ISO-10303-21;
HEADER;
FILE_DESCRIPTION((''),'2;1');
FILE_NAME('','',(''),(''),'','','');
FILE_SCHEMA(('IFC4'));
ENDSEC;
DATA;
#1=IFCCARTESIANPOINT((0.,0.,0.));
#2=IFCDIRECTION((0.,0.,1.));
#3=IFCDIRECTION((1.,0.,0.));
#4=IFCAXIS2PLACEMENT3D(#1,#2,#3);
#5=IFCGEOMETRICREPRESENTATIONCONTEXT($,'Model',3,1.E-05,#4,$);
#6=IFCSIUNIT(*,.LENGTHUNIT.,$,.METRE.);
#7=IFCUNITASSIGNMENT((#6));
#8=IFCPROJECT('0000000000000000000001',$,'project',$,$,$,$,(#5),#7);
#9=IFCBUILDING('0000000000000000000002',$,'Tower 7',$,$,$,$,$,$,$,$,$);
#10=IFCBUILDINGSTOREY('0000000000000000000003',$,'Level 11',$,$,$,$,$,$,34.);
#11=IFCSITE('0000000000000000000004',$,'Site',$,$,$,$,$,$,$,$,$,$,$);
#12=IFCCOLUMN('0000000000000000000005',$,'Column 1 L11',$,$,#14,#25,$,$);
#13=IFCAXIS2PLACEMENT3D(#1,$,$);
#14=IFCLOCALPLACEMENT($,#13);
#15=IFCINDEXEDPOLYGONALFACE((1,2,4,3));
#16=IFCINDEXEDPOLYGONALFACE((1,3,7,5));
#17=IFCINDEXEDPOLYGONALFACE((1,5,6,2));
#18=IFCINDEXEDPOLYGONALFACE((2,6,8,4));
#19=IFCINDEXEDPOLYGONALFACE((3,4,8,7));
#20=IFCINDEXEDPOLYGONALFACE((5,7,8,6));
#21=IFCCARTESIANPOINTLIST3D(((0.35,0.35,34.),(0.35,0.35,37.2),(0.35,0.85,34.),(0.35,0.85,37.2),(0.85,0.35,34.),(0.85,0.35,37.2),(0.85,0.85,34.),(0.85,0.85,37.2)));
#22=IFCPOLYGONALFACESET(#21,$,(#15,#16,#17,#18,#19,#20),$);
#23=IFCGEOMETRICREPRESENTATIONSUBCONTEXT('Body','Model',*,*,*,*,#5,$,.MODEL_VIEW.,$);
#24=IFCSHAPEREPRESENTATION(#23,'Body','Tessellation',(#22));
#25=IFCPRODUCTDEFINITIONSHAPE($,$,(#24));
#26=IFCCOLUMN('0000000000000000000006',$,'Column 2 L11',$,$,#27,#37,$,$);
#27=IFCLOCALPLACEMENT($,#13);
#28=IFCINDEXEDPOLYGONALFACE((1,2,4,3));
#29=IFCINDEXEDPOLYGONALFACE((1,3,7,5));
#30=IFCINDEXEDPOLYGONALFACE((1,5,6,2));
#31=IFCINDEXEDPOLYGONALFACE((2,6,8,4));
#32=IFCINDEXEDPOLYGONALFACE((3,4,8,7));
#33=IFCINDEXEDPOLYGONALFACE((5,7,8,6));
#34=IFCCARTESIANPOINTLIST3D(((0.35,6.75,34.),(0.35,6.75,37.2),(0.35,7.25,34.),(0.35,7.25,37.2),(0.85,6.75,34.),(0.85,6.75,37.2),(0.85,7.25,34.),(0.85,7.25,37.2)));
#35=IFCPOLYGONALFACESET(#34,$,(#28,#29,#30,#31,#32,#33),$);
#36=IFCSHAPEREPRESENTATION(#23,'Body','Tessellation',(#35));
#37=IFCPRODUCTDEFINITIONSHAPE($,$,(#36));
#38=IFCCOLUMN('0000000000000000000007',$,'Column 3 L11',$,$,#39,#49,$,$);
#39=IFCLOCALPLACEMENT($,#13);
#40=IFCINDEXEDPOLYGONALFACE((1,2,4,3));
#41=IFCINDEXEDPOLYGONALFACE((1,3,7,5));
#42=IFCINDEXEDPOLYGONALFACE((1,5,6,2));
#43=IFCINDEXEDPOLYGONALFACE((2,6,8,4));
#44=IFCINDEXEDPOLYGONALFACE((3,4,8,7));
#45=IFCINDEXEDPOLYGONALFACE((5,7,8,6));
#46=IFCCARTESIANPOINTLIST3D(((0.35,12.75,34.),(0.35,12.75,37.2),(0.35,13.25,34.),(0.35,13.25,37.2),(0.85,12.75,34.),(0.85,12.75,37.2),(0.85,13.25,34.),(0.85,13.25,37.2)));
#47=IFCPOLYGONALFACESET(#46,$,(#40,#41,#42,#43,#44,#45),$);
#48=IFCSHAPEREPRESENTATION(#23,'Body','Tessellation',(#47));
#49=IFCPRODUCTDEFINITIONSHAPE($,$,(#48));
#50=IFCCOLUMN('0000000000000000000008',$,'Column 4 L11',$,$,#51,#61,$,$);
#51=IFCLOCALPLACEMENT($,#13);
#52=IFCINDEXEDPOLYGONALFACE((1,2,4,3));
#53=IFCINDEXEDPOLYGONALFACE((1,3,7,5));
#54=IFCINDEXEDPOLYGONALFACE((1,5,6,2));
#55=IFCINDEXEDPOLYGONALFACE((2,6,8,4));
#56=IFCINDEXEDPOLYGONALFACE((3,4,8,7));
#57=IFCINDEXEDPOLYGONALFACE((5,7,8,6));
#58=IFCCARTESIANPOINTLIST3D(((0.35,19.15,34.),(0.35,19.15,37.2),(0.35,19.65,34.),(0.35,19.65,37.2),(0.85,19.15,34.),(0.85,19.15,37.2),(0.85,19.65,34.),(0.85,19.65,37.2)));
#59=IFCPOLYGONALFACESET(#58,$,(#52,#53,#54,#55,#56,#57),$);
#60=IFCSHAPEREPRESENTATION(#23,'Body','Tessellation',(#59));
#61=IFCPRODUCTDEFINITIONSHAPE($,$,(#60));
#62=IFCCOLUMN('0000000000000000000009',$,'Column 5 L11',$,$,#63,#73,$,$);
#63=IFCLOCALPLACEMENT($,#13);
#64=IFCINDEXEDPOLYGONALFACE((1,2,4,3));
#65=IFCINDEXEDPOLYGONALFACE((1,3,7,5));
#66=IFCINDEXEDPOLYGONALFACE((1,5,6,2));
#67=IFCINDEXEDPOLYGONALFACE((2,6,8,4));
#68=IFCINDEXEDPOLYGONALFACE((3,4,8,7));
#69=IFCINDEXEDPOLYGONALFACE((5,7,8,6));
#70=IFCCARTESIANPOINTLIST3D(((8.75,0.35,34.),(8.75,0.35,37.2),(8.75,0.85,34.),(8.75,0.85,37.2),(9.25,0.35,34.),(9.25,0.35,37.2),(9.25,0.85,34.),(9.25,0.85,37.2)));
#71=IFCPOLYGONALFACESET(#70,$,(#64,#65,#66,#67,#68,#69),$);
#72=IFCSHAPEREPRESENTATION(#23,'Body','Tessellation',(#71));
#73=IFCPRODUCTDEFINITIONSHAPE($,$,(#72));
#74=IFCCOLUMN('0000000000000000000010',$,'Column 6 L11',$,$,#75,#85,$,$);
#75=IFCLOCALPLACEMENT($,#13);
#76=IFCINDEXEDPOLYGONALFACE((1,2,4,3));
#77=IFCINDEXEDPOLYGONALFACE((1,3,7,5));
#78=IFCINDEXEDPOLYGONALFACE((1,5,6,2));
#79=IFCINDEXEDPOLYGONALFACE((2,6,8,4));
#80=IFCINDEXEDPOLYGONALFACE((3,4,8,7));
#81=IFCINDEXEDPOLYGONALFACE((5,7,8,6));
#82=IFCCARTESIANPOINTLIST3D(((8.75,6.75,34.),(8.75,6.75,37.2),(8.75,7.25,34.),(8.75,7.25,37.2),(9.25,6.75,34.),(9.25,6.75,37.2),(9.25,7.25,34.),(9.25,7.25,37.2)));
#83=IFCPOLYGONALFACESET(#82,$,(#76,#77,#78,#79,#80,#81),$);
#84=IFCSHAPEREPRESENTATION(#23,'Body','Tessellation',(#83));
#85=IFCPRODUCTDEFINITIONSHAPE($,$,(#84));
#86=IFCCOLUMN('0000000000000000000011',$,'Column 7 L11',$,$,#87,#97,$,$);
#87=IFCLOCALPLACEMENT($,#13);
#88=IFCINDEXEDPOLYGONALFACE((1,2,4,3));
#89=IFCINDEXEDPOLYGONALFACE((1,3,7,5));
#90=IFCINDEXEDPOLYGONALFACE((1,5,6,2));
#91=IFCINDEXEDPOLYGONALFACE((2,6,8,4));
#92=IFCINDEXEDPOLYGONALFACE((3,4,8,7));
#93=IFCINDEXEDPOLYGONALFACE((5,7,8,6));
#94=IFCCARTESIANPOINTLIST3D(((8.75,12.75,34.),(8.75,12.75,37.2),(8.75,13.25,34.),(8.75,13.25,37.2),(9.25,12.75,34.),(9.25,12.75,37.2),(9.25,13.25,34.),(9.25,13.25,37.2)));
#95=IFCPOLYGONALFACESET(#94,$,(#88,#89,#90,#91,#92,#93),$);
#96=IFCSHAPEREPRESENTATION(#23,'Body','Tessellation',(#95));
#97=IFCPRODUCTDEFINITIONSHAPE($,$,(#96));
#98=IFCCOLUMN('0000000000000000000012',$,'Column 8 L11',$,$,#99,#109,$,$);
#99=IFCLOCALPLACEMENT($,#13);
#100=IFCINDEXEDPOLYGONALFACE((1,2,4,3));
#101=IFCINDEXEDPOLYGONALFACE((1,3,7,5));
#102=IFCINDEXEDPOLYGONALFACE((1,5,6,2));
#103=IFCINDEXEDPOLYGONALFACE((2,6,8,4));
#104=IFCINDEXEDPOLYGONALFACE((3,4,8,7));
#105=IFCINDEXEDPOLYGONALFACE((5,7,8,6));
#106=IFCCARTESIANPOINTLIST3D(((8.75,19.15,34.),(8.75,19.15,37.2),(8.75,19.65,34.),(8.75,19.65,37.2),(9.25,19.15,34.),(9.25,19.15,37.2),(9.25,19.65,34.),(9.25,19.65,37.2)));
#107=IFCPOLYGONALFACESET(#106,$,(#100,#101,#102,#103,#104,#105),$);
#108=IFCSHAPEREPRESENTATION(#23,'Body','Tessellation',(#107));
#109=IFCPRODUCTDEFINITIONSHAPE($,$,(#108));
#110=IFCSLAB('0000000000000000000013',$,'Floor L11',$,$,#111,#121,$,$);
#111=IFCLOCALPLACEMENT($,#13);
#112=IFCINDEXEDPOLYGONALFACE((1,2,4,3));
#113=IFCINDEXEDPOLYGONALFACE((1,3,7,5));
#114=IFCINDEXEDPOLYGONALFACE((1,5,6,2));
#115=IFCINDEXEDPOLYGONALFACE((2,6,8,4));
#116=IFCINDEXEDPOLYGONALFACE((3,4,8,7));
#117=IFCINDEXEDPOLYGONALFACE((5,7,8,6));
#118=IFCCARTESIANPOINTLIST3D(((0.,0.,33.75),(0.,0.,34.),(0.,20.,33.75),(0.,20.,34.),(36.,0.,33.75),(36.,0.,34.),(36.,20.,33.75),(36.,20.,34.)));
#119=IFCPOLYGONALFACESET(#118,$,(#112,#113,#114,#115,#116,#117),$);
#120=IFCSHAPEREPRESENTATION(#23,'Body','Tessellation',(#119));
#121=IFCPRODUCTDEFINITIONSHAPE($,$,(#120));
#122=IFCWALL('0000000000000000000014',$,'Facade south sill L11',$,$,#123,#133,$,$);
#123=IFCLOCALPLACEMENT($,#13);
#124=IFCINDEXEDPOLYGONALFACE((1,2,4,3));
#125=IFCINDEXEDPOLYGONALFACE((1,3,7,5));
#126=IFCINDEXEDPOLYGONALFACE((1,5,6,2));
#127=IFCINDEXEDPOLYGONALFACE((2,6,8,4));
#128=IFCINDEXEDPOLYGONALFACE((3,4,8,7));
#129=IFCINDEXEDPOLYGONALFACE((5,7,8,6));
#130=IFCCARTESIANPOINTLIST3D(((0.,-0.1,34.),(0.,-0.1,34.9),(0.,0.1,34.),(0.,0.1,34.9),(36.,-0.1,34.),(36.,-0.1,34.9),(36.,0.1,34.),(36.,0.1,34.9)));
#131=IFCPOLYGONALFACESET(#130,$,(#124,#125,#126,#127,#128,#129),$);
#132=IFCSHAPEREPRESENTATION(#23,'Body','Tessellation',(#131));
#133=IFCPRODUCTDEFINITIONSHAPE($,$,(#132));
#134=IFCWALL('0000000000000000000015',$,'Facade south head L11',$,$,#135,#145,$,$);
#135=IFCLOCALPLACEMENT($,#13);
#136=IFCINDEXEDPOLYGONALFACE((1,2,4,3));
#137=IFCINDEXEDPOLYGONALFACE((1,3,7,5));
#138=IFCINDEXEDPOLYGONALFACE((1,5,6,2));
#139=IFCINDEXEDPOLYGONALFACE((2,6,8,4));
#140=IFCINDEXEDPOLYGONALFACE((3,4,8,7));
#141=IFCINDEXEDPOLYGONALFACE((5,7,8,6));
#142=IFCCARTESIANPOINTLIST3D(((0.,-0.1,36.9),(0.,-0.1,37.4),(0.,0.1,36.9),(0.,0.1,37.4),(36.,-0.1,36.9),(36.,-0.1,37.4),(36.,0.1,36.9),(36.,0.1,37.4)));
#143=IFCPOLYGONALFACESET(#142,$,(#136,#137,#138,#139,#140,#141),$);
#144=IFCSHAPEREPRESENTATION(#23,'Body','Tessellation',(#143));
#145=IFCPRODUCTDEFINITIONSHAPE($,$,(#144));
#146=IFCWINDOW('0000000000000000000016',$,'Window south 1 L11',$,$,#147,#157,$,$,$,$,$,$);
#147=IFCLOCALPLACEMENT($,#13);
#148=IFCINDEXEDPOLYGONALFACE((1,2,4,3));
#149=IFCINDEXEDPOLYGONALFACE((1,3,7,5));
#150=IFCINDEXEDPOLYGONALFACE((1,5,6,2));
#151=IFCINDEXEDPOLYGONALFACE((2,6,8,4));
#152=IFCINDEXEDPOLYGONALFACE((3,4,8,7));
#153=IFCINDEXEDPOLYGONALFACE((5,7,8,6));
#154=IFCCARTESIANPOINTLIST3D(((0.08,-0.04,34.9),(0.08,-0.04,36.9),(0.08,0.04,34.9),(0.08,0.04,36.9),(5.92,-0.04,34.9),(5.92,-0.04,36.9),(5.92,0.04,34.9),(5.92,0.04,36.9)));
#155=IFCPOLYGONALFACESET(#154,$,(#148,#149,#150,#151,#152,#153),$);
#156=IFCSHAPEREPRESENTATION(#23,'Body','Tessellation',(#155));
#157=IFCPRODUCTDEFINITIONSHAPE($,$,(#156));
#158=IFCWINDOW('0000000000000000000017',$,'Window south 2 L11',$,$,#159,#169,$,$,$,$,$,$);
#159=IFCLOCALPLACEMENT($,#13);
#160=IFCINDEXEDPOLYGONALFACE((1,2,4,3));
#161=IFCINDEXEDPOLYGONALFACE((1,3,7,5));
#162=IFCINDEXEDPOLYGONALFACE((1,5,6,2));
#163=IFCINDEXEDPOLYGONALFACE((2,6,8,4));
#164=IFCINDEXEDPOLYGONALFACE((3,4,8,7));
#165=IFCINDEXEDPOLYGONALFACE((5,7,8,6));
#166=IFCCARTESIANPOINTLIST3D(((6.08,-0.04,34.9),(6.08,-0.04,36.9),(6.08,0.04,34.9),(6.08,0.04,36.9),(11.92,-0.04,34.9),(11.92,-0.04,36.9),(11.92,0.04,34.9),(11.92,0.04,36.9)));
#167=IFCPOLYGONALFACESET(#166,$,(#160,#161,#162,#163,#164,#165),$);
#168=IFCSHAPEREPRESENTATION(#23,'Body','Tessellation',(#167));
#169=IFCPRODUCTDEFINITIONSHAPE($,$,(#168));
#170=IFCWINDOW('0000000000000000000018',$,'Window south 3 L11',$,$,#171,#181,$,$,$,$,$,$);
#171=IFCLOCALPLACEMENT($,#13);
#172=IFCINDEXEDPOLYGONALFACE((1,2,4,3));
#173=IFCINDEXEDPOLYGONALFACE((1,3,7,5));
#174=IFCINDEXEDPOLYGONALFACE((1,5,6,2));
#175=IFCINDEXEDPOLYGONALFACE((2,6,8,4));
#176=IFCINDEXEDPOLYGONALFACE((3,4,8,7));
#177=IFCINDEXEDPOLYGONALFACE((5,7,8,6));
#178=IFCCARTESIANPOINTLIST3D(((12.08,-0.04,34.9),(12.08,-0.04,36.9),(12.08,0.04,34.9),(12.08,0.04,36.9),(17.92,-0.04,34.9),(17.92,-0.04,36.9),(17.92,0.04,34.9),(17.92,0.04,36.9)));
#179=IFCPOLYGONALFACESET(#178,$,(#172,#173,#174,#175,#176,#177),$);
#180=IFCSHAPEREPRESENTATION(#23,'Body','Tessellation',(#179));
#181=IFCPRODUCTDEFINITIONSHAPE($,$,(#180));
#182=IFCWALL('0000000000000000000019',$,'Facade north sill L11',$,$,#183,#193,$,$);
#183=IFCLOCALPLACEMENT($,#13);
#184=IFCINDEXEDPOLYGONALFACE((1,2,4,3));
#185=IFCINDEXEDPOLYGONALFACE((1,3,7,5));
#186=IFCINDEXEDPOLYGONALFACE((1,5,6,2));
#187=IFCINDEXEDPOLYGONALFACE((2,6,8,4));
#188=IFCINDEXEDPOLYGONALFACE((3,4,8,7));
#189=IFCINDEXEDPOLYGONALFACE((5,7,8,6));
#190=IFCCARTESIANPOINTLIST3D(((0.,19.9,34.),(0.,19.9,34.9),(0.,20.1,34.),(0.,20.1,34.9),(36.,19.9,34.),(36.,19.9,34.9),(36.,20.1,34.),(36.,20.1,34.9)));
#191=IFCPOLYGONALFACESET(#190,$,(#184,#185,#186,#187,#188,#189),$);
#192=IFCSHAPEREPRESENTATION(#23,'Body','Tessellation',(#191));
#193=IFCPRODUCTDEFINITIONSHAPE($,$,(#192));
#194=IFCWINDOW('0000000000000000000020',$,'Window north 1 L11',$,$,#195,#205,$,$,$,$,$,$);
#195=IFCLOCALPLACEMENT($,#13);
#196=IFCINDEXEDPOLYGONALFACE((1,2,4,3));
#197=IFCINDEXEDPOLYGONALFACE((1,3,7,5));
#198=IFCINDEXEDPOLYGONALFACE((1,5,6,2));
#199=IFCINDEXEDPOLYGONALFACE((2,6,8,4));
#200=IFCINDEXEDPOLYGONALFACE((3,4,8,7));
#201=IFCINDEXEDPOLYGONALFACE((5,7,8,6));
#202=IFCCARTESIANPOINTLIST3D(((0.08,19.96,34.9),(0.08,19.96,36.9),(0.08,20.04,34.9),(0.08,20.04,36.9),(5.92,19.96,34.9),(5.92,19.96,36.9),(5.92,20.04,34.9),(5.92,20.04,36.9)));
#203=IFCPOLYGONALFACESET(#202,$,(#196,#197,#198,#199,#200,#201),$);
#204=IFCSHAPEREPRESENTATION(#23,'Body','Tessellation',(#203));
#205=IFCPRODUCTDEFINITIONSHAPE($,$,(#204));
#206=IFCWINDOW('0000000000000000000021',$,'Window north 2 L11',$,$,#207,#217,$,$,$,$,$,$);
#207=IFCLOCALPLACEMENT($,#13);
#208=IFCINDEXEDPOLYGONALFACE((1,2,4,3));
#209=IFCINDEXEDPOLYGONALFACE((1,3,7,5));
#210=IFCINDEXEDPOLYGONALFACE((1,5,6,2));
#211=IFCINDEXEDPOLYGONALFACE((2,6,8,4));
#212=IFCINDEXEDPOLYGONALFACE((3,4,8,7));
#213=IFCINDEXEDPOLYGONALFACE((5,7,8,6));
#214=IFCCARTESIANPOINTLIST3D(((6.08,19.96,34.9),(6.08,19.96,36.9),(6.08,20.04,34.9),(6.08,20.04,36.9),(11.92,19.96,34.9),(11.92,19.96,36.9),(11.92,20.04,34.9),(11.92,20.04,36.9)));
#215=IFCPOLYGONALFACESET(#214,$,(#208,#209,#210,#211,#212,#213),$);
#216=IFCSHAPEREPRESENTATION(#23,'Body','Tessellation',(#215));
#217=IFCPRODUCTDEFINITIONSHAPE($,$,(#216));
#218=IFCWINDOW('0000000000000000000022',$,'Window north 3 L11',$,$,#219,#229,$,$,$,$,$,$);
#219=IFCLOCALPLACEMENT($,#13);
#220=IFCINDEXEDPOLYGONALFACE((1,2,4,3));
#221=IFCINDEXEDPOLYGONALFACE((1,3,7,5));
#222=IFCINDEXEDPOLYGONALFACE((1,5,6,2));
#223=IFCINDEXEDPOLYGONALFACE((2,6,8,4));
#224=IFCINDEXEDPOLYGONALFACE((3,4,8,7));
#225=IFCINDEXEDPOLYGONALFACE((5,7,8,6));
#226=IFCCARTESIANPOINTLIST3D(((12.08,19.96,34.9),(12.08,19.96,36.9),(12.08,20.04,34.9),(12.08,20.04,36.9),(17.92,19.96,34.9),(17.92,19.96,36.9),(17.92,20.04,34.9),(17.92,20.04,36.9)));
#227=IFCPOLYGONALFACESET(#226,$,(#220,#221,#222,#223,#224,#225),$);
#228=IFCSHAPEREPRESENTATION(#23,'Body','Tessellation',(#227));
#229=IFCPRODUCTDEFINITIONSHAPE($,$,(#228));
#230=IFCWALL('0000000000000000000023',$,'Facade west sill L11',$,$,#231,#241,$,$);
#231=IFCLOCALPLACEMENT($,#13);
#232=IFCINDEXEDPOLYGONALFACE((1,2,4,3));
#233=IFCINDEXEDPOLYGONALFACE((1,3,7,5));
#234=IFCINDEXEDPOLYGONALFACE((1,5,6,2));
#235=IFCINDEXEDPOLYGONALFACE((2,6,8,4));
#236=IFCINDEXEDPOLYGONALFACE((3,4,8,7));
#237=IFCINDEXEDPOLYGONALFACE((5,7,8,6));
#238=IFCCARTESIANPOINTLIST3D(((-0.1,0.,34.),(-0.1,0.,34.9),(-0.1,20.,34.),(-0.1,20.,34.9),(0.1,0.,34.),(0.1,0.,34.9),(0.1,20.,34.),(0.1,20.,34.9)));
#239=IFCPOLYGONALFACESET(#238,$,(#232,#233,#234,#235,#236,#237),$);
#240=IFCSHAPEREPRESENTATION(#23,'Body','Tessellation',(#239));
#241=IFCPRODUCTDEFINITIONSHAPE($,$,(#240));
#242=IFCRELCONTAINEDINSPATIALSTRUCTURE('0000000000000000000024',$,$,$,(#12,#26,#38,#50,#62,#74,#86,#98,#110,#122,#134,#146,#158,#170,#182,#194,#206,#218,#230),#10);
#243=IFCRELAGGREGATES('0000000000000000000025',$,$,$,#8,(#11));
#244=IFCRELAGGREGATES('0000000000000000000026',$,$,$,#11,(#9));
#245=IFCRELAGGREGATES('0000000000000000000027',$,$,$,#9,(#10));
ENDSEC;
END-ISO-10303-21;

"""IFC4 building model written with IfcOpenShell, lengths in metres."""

from ifc_helpers import new_model, si_unit, frame, origin, origin_with_axes, origin_2d, place, context, subcontext, project, spatial, rectangle, extrude, element, save


model = new_model("IFC4")

# Units and contexts
model_context = context("Model", 3, precision=1e-05, world=origin_with_axes())
body_context = subcontext(model_context, "Body", "Model", "MODEL_VIEW")
ifc_project = project(units=[si_unit("LENGTHUNIT", "METRE")], contexts=[model_context])

# Site, building, storey
site = spatial("IfcSite", under=ifc_project, Name="Site")
building = spatial("IfcBuilding", under=site, Name="Tower 7")
storey = spatial("IfcBuildingStorey", under=building, Name="Level 11", Elevation=34.0)

# Columns
for number, where, z_axis, x_axis, name in (
    (1, (0.6, 0.6, 34.0), (0.0, 0.0, 1.0), (1.0, 0.0, 0.0), "Column 1 L11"),
    (2, (0.6, 7.0, 34.0), (0.0, 0.0, 1.0), (1.0, 0.0, 0.0), "Column 2 L11"),
    (3, (0.6, 13.0, 34.0), (0.0, 0.0, 1.0), (1.0, 0.0, 0.0), "Column 3 L11"),
    (4, (0.6, 19.4, 34.0), (0.0, 0.0, 1.0), (1.0, 0.0, 0.0), "Column 4 L11"),
    (5, (9.0, 0.6, 34.0), (0.0, 0.0, 1.0), (1.0, 0.0, 0.0), "Column 5 L11"),
    (6, (9.0, 7.0, 34.0), (0.0, 0.0, 1.0), (1.0, 0.0, 0.0), "Column 6 L11"),
    (7, (9.0, 13.0, 34.0), (0.0, 0.0, 1.0), (1.0, 0.0, 0.0), "Column 7 L11"),
    (8, (9.0, 19.4, 34.0), (0.0, 0.0, 1.0), (1.0, 0.0, 0.0), "Column 8 L11"),
):
    element("IfcColumn", number, at=place(None, frame(where, z_axis=z_axis, x_axis=x_axis)), inside=storey, Name=name, context=body_context, shape_type="SweptSolid", body=[
        extrude(rectangle(XDim=0.5, YDim=0.5, at=origin_2d()), origin(), (0.0, 0.0, 1.0), 3.2),
    ])

# Slab
slab_placement = place(None, frame((18.0, 10.0, 33.75), z_axis=(0.0, 0.0, 1.0), x_axis=(1.0, 0.0, 0.0)))
element("IfcSlab", 9, at=slab_placement, inside=storey, Name="Floor L11", context=body_context, shape_type="SweptSolid", body=[
    extrude(rectangle(XDim=36.0, YDim=20.0, at=origin_2d()), origin(), (0.0, 0.0, 1.0), 0.25),
])

# Walls
wall_1_placement = place(None, frame((18.0, 0.0, 34.0), z_axis=(0.0, 0.0, 1.0), x_axis=(1.0, 0.0, 0.0)))
element("IfcWall", 10, at=wall_1_placement, inside=storey, Name="Facade south sill L11", context=body_context, shape_type="SweptSolid", body=[
    extrude(rectangle(XDim=36.0, YDim=0.2, at=origin_2d()), origin(), (0.0, 0.0, 1.0), 0.9),
])
wall_2_placement = place(None, frame((18.0, 0.0, 36.9), z_axis=(0.0, 0.0, 1.0), x_axis=(1.0, 0.0, 0.0)))
element("IfcWall", 11, at=wall_2_placement, inside=storey, Name="Facade south head L11", context=body_context, shape_type="SweptSolid", body=[
    extrude(rectangle(XDim=36.0, YDim=0.2, at=origin_2d()), origin(), (0.0, 0.0, 1.0), 0.5),
])

# Windows
for number, where, z_axis, x_axis, name in (
    (12, (3.0, 0.0, 34.9), (0.0, 0.0, 1.0), (1.0, 0.0, 0.0), "Window south 1 L11"),
    (13, (9.0, 0.0, 34.9), (0.0, 0.0, 1.0), (1.0, 0.0, 0.0), "Window south 2 L11"),
):
    element("IfcWindow", number, at=place(None, frame(where, z_axis=z_axis, x_axis=x_axis)), inside=storey, Name=name, context=body_context, shape_type="SweptSolid", body=[
        extrude(rectangle(XDim=5.84, YDim=0.08, at=origin_2d()), origin(), (0.0, 0.0, 1.0), 2.0),
    ])
window_1_placement = place(None, frame((15.0, 0.0, 34.9), z_axis=(0.0, 0.0, 1.0), x_axis=(1.0, 0.0, 0.0)))
element("IfcWindow", 14, at=window_1_placement, inside=storey, Name="Window south 3 L11", context=body_context, shape_type="SweptSolid", body=[
    extrude(rectangle(XDim=5.84, YDim=0.08, at=origin_2d()), origin(), (0.0, 0.0, 1.0), 2.0),
])

# Wall
wall_3_placement = place(None, frame((18.0, 20.0, 34.0), z_axis=(0.0, 0.0, 1.0), x_axis=(1.0, 0.0, 0.0)))
element("IfcWall", 15, at=wall_3_placement, inside=storey, Name="Facade north sill L11", context=body_context, shape_type="SweptSolid", body=[
    extrude(rectangle(XDim=36.0, YDim=0.2, at=origin_2d()), origin(), (0.0, 0.0, 1.0), 0.9),
])

# Windows
for number, where, z_axis, x_axis, name in (
    (16, (3.0, 20.0, 34.9), (0.0, 0.0, 1.0), (1.0, 0.0, 0.0), "Window north 1 L11"),
    (17, (9.0, 20.0, 34.9), (0.0, 0.0, 1.0), (1.0, 0.0, 0.0), "Window north 2 L11"),
):
    element("IfcWindow", number, at=place(None, frame(where, z_axis=z_axis, x_axis=x_axis)), inside=storey, Name=name, context=body_context, shape_type="SweptSolid", body=[
        extrude(rectangle(XDim=5.84, YDim=0.08, at=origin_2d()), origin(), (0.0, 0.0, 1.0), 2.0),
    ])
window_2_placement = place(None, frame((15.0, 20.0, 34.9), z_axis=(0.0, 0.0, 1.0), x_axis=(1.0, 0.0, 0.0)))
element("IfcWindow", 18, at=window_2_placement, inside=storey, Name="Window north 3 L11", context=body_context, shape_type="SweptSolid", body=[
    extrude(rectangle(XDim=5.84, YDim=0.08, at=origin_2d()), origin(), (0.0, 0.0, 1.0), 2.0),
])

# Wall
wall_4_placement = place(None, frame((0.0, 10.0, 34.0), z_axis=(0.0, 0.0, 1.0), x_axis=(1.0, 0.0, 0.0)))
element("IfcWall", 19, at=wall_4_placement, inside=storey, Name="Facade west sill L11", context=body_context, shape_type="SweptSolid", body=[
    extrude(rectangle(XDim=0.2, YDim=20.0, at=origin_2d()), origin(), (0.0, 0.0, 1.0), 0.9),
])

save(model, "model.ifc")
